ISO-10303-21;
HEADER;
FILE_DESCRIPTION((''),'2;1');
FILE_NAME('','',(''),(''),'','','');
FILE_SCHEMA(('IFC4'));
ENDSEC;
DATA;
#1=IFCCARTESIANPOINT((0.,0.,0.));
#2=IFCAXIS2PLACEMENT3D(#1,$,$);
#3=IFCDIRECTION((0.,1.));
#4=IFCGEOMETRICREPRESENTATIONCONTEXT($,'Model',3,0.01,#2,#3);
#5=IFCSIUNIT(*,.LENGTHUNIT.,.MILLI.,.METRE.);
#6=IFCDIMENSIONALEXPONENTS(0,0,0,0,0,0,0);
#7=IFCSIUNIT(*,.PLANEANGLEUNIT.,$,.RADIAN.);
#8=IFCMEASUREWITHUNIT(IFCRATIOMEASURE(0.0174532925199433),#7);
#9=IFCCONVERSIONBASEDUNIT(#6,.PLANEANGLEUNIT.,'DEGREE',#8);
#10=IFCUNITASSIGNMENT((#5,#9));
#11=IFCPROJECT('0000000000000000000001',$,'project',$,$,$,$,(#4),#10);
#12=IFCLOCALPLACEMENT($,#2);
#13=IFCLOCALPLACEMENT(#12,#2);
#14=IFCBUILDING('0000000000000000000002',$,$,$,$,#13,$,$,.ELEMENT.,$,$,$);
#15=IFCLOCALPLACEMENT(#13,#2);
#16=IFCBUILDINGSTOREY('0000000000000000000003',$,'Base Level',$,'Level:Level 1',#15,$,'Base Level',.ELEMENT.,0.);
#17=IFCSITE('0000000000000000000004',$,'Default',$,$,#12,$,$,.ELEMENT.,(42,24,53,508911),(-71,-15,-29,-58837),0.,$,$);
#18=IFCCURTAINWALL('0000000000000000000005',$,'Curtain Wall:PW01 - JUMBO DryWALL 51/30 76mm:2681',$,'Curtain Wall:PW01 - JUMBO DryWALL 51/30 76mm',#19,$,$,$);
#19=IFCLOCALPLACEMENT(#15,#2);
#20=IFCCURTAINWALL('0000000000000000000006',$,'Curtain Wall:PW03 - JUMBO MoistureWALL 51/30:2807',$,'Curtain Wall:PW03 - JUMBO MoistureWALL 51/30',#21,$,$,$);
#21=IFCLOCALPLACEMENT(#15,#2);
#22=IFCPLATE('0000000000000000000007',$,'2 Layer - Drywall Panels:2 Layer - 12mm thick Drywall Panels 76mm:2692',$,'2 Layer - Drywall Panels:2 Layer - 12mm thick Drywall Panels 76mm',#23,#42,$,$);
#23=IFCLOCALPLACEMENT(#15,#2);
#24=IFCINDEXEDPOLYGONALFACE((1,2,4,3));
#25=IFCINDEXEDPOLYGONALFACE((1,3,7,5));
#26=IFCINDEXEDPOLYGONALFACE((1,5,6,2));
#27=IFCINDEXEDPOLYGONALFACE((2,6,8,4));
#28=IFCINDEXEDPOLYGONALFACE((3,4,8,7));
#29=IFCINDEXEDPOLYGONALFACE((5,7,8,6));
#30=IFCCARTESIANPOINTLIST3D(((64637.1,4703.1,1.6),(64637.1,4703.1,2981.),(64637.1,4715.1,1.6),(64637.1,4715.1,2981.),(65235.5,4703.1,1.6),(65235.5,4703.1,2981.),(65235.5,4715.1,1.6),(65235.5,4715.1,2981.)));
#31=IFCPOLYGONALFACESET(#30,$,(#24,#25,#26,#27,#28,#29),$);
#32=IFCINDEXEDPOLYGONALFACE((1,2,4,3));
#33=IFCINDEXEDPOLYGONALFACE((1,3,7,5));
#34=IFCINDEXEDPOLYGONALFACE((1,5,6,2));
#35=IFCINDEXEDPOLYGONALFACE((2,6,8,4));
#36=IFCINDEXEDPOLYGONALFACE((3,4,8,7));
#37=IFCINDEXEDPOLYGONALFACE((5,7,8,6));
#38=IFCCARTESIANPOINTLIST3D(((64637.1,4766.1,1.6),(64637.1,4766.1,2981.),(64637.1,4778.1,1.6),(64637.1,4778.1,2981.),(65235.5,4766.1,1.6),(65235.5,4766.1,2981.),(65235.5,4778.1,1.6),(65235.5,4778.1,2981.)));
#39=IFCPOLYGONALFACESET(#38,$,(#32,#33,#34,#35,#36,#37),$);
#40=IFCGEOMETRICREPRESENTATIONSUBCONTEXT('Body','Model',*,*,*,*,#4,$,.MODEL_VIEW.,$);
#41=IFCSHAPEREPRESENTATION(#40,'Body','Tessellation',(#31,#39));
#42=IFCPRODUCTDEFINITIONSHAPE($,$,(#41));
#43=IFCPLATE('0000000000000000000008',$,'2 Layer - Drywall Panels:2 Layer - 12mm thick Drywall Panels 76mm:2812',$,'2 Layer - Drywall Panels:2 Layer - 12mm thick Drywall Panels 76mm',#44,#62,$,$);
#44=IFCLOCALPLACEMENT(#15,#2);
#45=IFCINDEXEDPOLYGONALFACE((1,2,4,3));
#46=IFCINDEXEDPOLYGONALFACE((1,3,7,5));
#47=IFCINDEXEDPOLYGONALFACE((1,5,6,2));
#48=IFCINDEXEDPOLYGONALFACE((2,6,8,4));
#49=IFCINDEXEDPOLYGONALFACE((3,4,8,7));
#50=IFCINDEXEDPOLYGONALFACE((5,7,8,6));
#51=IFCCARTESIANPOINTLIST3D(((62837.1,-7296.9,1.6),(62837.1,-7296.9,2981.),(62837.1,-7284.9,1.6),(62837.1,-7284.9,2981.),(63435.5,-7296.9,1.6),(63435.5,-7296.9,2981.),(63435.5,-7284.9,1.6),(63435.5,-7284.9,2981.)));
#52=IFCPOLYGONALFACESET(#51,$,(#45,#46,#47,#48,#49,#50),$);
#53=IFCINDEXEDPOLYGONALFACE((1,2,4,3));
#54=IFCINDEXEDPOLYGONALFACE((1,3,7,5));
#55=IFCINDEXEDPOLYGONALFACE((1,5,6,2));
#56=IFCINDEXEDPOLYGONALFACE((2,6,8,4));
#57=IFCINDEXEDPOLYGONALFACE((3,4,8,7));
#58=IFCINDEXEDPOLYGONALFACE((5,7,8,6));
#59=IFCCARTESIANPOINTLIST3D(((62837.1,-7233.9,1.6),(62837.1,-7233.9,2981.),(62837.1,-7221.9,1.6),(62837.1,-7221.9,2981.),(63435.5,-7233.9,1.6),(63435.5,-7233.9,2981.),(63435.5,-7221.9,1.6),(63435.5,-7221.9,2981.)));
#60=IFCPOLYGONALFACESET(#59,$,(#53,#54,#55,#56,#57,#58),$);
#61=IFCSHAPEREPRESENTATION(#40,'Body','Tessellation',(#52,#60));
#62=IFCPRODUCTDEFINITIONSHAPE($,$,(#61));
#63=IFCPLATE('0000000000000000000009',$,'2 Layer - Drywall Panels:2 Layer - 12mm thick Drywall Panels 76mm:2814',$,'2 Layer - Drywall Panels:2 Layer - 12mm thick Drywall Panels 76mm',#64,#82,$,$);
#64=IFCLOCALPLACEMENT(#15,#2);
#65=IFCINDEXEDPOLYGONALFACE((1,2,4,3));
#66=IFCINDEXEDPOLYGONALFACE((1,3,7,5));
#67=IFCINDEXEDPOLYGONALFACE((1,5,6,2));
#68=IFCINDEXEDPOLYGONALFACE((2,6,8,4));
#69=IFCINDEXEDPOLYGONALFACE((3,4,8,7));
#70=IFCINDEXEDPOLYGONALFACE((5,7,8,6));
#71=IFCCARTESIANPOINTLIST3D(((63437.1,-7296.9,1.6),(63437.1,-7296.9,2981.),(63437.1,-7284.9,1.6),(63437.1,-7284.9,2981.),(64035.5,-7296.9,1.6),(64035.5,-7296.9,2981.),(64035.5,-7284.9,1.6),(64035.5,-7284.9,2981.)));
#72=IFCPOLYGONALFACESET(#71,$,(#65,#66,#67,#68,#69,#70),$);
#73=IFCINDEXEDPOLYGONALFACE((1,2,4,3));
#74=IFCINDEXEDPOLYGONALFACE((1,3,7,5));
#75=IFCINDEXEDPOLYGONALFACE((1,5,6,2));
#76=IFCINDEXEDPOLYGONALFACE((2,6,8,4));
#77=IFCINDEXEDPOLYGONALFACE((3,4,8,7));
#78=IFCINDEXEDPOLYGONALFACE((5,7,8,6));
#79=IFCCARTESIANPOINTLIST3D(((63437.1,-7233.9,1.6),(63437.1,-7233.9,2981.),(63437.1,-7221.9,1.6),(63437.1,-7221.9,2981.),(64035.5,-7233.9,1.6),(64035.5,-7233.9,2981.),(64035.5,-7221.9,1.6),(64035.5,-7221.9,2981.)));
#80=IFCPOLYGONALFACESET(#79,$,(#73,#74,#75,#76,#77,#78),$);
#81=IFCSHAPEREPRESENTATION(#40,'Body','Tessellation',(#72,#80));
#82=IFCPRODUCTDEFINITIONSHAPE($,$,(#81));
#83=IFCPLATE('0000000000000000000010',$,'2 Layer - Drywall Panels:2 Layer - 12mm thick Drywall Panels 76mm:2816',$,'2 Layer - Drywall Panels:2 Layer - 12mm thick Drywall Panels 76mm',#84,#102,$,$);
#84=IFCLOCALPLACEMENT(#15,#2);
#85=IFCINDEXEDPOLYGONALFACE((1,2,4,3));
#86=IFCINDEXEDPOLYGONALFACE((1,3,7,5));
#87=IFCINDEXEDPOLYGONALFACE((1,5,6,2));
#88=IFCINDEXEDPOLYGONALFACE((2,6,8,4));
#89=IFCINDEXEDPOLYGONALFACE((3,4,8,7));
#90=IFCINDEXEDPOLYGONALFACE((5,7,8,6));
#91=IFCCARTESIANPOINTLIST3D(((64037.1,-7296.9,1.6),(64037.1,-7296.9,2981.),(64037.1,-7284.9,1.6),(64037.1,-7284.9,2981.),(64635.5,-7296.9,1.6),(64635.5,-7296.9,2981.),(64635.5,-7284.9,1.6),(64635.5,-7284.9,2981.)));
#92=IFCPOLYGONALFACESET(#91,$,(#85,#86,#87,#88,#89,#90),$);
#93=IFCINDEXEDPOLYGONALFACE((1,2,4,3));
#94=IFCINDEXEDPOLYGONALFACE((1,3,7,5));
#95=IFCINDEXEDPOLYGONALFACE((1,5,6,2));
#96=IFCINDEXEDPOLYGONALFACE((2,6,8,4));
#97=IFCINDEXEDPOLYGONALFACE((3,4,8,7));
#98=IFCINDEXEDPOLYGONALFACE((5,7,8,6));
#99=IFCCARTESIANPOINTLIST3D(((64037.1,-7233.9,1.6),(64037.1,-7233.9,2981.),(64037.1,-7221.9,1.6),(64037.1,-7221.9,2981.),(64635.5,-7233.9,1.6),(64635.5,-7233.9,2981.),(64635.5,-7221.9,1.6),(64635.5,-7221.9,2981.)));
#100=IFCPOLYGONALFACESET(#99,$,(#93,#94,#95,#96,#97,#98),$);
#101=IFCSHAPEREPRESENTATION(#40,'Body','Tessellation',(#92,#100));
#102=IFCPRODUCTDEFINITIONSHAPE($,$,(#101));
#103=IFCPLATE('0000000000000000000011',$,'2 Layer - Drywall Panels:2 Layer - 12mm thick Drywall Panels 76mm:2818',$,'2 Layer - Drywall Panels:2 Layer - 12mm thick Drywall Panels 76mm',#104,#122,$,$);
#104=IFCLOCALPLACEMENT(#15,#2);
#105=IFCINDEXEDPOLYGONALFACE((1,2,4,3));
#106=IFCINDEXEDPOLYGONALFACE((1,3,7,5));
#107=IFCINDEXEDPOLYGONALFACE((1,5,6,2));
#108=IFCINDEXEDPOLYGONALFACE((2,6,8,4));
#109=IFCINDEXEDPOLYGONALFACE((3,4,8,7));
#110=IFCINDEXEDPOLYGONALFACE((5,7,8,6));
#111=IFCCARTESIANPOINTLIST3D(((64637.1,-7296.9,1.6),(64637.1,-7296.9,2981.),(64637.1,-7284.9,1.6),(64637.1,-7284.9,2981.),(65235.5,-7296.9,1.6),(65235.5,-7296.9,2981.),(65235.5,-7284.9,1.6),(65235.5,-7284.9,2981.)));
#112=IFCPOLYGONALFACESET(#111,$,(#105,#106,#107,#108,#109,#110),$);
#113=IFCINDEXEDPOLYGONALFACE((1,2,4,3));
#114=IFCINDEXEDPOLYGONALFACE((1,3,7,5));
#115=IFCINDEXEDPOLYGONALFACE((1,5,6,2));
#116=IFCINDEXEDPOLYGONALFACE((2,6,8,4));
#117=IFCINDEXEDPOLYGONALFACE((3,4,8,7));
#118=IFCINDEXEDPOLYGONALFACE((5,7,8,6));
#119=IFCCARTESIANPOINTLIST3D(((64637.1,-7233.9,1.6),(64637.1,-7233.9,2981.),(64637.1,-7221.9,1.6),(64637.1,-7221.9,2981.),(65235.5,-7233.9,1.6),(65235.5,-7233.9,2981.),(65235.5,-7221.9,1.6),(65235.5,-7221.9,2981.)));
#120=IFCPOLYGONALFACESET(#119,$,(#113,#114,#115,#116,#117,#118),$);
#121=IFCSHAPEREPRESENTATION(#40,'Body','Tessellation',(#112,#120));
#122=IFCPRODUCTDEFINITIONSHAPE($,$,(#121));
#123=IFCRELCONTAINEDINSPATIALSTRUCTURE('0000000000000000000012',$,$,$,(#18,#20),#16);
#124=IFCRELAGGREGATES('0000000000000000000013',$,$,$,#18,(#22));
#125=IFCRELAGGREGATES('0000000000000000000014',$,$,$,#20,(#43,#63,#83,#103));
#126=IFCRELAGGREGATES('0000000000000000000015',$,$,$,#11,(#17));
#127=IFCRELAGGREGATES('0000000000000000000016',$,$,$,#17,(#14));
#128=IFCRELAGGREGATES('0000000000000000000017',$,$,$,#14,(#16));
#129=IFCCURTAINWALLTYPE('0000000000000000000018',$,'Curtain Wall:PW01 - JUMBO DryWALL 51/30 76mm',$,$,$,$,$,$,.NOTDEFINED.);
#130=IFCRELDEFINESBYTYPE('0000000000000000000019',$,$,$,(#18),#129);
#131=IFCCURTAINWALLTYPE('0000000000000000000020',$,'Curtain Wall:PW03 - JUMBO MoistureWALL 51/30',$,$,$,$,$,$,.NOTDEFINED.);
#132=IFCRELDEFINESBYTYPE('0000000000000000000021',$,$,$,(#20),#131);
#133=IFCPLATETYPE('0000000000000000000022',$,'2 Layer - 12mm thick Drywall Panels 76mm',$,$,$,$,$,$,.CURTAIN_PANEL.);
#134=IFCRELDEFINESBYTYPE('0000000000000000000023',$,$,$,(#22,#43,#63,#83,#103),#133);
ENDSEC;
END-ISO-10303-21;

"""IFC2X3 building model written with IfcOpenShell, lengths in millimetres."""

from ifc_helpers import new_model, entity, si_unit, converted_unit, direction, frame, frame_2d, origin, origin_2d_with_axis, place, context, subcontext, project, spatial, rectangle, extrude, source, transform, mapped, type_object, type_shapes, element, aggregate, save


model = new_model("IFC2X3")

# Units and contexts
model_context = context("Model", 3, precision=0.01, world=origin(), true_north=direction((0.0, 1.0)))
body_context = subcontext(model_context, "Body", "Model", "MODEL_VIEW")
ifc_project = project(units=[si_unit("LENGTHUNIT", "METRE", prefix="MILLI"), converted_unit("PLANEANGLEUNIT", "DEGREE", entity("IfcRatioMeasure", 0.0174532925199433), si_unit("PLANEANGLEUNIT", "RADIAN"), dimensions=[0, 0, 0, 0, 0, 0, 0])], contexts=[model_context])

# Site, building, storey
site_placement = place(None, origin())
site = spatial("IfcSite", under=ifc_project, at=site_placement, Name="Default", CompositionType="ELEMENT", RefLatitude=(42, 24, 53, 508911), RefLongitude=(-71, -15, -29, -58837), RefElevation=0.0)
building_placement = place(site_placement, origin())
building = spatial("IfcBuilding", under=site, at=building_placement, CompositionType="ELEMENT")
storey_placement = place(building_placement, origin())
storey = spatial("IfcBuildingStorey", under=building, at=storey_placement, Name="Base Level", ObjectType="Level:Level 1", LongName="Base Level", CompositionType="ELEMENT", Elevation=0.0)

# Curtain walls
curtain_wall_type_1 = type_object("IfcCurtainWallType", Name="Curtain Wall:PW01 - JUMBO DryWALL 51/30 76mm", PredefinedType="NOTDEFINED")
curtain_wall_1_placement = place(building_placement, origin())
curtain_wall_1 = element("IfcCurtainWall", 1, at=curtain_wall_1_placement, inside=storey, type_object=curtain_wall_type_1, Name="Curtain Wall:PW01 - JUMBO DryWALL 51/30 76mm:2681", ObjectType="Curtain Wall:PW01 - JUMBO DryWALL 51/30 76mm")
curtain_wall_type_2 = type_object("IfcCurtainWallType", Name="Curtain Wall:PW03 - JUMBO MoistureWALL 51/30", PredefinedType="NOTDEFINED")
curtain_wall_2_placement = place(building_placement, origin())
curtain_wall_2 = element("IfcCurtainWall", 2, at=curtain_wall_2_placement, inside=storey, type_object=curtain_wall_type_2, Name="Curtain Wall:PW03 - JUMBO MoistureWALL 51/30:2807", ObjectType="Curtain Wall:PW03 - JUMBO MoistureWALL 51/30")

# Plates
plate_type = type_object("IfcPlateType", Name="2 Layer - 12mm thick Drywall Panels 76mm", PredefinedType="CURTAIN_PANEL")
shared_shape_1 = source(origin(), body_context, "Body", "SweptSolid", [
    extrude(rectangle(XDim=598.4, YDim=12.0, at=origin_2d_with_axis()), frame((0.0, -31.5, 0.0), z_axis=(0.0, 0.0, 1.0), x_axis=(-1.0, 0.0, 0.0)), (0.0, 0.0, 1.0), 2979.4),
    extrude(rectangle(XDim=12.0, YDim=598.4, at=frame_2d((0.0, 0.0), x_axis=(1.0, 0.0))), frame((0.0, 31.5, 0.0), z_axis=(0.0, 0.0, 1.0), x_axis=(0.0, 1.0, 0.0)), (0.0, 0.0, 1.0), 2979.4),
])
type_shapes(plate_type, [shared_shape_1])
plate_1_placement = place(curtain_wall_1_placement, frame((64936.3, 4740.6, 1.6)))
plate_1 = element("IfcPlate", 3, at=plate_1_placement, type_object=plate_type, Name="2 Layer - Drywall Panels:2 Layer - 12mm thick Drywall Panels 76mm:2692", ObjectType="2 Layer - Drywall Panels:2 Layer - 12mm thick Drywall Panels 76mm", context=body_context, shape_type="MappedRepresentation", body=[
    mapped(shared_shape_1, transform((0.0, 0.0, 0.0), scale=1.0)),
])
aggregate(curtain_wall_1, [plate_1])
plate_2_placement = place(curtain_wall_2_placement, frame((63136.3, -7259.4, 1.6)))
plate_2 = element("IfcPlate", 4, at=plate_2_placement, type_object=plate_type, Name="2 Layer - Drywall Panels:2 Layer - 12mm thick Drywall Panels 76mm:2812", ObjectType="2 Layer - Drywall Panels:2 Layer - 12mm thick Drywall Panels 76mm", context=body_context, shape_type="MappedRepresentation", body=[
    mapped(shared_shape_1, transform((0.0, 0.0, 0.0), scale=1.0)),
])
plate_3_placement = place(curtain_wall_2_placement, frame((63736.3, -7259.4, 1.6)))
plate_3 = element("IfcPlate", 5, at=plate_3_placement, type_object=plate_type, Name="2 Layer - Drywall Panels:2 Layer - 12mm thick Drywall Panels 76mm:2814", ObjectType="2 Layer - Drywall Panels:2 Layer - 12mm thick Drywall Panels 76mm", context=body_context, shape_type="MappedRepresentation", body=[
    mapped(shared_shape_1, transform((0.0, 0.0, 0.0), scale=1.0)),
])
plate_4_placement = place(curtain_wall_2_placement, frame((64336.3, -7259.4, 1.6)))
plate_4 = element("IfcPlate", 6, at=plate_4_placement, type_object=plate_type, Name="2 Layer - Drywall Panels:2 Layer - 12mm thick Drywall Panels 76mm:2816", ObjectType="2 Layer - Drywall Panels:2 Layer - 12mm thick Drywall Panels 76mm", context=body_context, shape_type="MappedRepresentation", body=[
    mapped(shared_shape_1, transform((0.0, 0.0, 0.0), scale=1.0)),
])
plate_5_placement = place(curtain_wall_2_placement, frame((64936.3, -7259.4, 1.6)))
plate_5 = element("IfcPlate", 7, at=plate_5_placement, type_object=plate_type, Name="2 Layer - Drywall Panels:2 Layer - 12mm thick Drywall Panels 76mm:2818", ObjectType="2 Layer - Drywall Panels:2 Layer - 12mm thick Drywall Panels 76mm", context=body_context, shape_type="MappedRepresentation", body=[
    mapped(shared_shape_1, transform((0.0, 0.0, 0.0), scale=1.0)),
])
aggregate(curtain_wall_2, [plate_2, plate_3, plate_4, plate_5])

save(model, "model.ifc")
